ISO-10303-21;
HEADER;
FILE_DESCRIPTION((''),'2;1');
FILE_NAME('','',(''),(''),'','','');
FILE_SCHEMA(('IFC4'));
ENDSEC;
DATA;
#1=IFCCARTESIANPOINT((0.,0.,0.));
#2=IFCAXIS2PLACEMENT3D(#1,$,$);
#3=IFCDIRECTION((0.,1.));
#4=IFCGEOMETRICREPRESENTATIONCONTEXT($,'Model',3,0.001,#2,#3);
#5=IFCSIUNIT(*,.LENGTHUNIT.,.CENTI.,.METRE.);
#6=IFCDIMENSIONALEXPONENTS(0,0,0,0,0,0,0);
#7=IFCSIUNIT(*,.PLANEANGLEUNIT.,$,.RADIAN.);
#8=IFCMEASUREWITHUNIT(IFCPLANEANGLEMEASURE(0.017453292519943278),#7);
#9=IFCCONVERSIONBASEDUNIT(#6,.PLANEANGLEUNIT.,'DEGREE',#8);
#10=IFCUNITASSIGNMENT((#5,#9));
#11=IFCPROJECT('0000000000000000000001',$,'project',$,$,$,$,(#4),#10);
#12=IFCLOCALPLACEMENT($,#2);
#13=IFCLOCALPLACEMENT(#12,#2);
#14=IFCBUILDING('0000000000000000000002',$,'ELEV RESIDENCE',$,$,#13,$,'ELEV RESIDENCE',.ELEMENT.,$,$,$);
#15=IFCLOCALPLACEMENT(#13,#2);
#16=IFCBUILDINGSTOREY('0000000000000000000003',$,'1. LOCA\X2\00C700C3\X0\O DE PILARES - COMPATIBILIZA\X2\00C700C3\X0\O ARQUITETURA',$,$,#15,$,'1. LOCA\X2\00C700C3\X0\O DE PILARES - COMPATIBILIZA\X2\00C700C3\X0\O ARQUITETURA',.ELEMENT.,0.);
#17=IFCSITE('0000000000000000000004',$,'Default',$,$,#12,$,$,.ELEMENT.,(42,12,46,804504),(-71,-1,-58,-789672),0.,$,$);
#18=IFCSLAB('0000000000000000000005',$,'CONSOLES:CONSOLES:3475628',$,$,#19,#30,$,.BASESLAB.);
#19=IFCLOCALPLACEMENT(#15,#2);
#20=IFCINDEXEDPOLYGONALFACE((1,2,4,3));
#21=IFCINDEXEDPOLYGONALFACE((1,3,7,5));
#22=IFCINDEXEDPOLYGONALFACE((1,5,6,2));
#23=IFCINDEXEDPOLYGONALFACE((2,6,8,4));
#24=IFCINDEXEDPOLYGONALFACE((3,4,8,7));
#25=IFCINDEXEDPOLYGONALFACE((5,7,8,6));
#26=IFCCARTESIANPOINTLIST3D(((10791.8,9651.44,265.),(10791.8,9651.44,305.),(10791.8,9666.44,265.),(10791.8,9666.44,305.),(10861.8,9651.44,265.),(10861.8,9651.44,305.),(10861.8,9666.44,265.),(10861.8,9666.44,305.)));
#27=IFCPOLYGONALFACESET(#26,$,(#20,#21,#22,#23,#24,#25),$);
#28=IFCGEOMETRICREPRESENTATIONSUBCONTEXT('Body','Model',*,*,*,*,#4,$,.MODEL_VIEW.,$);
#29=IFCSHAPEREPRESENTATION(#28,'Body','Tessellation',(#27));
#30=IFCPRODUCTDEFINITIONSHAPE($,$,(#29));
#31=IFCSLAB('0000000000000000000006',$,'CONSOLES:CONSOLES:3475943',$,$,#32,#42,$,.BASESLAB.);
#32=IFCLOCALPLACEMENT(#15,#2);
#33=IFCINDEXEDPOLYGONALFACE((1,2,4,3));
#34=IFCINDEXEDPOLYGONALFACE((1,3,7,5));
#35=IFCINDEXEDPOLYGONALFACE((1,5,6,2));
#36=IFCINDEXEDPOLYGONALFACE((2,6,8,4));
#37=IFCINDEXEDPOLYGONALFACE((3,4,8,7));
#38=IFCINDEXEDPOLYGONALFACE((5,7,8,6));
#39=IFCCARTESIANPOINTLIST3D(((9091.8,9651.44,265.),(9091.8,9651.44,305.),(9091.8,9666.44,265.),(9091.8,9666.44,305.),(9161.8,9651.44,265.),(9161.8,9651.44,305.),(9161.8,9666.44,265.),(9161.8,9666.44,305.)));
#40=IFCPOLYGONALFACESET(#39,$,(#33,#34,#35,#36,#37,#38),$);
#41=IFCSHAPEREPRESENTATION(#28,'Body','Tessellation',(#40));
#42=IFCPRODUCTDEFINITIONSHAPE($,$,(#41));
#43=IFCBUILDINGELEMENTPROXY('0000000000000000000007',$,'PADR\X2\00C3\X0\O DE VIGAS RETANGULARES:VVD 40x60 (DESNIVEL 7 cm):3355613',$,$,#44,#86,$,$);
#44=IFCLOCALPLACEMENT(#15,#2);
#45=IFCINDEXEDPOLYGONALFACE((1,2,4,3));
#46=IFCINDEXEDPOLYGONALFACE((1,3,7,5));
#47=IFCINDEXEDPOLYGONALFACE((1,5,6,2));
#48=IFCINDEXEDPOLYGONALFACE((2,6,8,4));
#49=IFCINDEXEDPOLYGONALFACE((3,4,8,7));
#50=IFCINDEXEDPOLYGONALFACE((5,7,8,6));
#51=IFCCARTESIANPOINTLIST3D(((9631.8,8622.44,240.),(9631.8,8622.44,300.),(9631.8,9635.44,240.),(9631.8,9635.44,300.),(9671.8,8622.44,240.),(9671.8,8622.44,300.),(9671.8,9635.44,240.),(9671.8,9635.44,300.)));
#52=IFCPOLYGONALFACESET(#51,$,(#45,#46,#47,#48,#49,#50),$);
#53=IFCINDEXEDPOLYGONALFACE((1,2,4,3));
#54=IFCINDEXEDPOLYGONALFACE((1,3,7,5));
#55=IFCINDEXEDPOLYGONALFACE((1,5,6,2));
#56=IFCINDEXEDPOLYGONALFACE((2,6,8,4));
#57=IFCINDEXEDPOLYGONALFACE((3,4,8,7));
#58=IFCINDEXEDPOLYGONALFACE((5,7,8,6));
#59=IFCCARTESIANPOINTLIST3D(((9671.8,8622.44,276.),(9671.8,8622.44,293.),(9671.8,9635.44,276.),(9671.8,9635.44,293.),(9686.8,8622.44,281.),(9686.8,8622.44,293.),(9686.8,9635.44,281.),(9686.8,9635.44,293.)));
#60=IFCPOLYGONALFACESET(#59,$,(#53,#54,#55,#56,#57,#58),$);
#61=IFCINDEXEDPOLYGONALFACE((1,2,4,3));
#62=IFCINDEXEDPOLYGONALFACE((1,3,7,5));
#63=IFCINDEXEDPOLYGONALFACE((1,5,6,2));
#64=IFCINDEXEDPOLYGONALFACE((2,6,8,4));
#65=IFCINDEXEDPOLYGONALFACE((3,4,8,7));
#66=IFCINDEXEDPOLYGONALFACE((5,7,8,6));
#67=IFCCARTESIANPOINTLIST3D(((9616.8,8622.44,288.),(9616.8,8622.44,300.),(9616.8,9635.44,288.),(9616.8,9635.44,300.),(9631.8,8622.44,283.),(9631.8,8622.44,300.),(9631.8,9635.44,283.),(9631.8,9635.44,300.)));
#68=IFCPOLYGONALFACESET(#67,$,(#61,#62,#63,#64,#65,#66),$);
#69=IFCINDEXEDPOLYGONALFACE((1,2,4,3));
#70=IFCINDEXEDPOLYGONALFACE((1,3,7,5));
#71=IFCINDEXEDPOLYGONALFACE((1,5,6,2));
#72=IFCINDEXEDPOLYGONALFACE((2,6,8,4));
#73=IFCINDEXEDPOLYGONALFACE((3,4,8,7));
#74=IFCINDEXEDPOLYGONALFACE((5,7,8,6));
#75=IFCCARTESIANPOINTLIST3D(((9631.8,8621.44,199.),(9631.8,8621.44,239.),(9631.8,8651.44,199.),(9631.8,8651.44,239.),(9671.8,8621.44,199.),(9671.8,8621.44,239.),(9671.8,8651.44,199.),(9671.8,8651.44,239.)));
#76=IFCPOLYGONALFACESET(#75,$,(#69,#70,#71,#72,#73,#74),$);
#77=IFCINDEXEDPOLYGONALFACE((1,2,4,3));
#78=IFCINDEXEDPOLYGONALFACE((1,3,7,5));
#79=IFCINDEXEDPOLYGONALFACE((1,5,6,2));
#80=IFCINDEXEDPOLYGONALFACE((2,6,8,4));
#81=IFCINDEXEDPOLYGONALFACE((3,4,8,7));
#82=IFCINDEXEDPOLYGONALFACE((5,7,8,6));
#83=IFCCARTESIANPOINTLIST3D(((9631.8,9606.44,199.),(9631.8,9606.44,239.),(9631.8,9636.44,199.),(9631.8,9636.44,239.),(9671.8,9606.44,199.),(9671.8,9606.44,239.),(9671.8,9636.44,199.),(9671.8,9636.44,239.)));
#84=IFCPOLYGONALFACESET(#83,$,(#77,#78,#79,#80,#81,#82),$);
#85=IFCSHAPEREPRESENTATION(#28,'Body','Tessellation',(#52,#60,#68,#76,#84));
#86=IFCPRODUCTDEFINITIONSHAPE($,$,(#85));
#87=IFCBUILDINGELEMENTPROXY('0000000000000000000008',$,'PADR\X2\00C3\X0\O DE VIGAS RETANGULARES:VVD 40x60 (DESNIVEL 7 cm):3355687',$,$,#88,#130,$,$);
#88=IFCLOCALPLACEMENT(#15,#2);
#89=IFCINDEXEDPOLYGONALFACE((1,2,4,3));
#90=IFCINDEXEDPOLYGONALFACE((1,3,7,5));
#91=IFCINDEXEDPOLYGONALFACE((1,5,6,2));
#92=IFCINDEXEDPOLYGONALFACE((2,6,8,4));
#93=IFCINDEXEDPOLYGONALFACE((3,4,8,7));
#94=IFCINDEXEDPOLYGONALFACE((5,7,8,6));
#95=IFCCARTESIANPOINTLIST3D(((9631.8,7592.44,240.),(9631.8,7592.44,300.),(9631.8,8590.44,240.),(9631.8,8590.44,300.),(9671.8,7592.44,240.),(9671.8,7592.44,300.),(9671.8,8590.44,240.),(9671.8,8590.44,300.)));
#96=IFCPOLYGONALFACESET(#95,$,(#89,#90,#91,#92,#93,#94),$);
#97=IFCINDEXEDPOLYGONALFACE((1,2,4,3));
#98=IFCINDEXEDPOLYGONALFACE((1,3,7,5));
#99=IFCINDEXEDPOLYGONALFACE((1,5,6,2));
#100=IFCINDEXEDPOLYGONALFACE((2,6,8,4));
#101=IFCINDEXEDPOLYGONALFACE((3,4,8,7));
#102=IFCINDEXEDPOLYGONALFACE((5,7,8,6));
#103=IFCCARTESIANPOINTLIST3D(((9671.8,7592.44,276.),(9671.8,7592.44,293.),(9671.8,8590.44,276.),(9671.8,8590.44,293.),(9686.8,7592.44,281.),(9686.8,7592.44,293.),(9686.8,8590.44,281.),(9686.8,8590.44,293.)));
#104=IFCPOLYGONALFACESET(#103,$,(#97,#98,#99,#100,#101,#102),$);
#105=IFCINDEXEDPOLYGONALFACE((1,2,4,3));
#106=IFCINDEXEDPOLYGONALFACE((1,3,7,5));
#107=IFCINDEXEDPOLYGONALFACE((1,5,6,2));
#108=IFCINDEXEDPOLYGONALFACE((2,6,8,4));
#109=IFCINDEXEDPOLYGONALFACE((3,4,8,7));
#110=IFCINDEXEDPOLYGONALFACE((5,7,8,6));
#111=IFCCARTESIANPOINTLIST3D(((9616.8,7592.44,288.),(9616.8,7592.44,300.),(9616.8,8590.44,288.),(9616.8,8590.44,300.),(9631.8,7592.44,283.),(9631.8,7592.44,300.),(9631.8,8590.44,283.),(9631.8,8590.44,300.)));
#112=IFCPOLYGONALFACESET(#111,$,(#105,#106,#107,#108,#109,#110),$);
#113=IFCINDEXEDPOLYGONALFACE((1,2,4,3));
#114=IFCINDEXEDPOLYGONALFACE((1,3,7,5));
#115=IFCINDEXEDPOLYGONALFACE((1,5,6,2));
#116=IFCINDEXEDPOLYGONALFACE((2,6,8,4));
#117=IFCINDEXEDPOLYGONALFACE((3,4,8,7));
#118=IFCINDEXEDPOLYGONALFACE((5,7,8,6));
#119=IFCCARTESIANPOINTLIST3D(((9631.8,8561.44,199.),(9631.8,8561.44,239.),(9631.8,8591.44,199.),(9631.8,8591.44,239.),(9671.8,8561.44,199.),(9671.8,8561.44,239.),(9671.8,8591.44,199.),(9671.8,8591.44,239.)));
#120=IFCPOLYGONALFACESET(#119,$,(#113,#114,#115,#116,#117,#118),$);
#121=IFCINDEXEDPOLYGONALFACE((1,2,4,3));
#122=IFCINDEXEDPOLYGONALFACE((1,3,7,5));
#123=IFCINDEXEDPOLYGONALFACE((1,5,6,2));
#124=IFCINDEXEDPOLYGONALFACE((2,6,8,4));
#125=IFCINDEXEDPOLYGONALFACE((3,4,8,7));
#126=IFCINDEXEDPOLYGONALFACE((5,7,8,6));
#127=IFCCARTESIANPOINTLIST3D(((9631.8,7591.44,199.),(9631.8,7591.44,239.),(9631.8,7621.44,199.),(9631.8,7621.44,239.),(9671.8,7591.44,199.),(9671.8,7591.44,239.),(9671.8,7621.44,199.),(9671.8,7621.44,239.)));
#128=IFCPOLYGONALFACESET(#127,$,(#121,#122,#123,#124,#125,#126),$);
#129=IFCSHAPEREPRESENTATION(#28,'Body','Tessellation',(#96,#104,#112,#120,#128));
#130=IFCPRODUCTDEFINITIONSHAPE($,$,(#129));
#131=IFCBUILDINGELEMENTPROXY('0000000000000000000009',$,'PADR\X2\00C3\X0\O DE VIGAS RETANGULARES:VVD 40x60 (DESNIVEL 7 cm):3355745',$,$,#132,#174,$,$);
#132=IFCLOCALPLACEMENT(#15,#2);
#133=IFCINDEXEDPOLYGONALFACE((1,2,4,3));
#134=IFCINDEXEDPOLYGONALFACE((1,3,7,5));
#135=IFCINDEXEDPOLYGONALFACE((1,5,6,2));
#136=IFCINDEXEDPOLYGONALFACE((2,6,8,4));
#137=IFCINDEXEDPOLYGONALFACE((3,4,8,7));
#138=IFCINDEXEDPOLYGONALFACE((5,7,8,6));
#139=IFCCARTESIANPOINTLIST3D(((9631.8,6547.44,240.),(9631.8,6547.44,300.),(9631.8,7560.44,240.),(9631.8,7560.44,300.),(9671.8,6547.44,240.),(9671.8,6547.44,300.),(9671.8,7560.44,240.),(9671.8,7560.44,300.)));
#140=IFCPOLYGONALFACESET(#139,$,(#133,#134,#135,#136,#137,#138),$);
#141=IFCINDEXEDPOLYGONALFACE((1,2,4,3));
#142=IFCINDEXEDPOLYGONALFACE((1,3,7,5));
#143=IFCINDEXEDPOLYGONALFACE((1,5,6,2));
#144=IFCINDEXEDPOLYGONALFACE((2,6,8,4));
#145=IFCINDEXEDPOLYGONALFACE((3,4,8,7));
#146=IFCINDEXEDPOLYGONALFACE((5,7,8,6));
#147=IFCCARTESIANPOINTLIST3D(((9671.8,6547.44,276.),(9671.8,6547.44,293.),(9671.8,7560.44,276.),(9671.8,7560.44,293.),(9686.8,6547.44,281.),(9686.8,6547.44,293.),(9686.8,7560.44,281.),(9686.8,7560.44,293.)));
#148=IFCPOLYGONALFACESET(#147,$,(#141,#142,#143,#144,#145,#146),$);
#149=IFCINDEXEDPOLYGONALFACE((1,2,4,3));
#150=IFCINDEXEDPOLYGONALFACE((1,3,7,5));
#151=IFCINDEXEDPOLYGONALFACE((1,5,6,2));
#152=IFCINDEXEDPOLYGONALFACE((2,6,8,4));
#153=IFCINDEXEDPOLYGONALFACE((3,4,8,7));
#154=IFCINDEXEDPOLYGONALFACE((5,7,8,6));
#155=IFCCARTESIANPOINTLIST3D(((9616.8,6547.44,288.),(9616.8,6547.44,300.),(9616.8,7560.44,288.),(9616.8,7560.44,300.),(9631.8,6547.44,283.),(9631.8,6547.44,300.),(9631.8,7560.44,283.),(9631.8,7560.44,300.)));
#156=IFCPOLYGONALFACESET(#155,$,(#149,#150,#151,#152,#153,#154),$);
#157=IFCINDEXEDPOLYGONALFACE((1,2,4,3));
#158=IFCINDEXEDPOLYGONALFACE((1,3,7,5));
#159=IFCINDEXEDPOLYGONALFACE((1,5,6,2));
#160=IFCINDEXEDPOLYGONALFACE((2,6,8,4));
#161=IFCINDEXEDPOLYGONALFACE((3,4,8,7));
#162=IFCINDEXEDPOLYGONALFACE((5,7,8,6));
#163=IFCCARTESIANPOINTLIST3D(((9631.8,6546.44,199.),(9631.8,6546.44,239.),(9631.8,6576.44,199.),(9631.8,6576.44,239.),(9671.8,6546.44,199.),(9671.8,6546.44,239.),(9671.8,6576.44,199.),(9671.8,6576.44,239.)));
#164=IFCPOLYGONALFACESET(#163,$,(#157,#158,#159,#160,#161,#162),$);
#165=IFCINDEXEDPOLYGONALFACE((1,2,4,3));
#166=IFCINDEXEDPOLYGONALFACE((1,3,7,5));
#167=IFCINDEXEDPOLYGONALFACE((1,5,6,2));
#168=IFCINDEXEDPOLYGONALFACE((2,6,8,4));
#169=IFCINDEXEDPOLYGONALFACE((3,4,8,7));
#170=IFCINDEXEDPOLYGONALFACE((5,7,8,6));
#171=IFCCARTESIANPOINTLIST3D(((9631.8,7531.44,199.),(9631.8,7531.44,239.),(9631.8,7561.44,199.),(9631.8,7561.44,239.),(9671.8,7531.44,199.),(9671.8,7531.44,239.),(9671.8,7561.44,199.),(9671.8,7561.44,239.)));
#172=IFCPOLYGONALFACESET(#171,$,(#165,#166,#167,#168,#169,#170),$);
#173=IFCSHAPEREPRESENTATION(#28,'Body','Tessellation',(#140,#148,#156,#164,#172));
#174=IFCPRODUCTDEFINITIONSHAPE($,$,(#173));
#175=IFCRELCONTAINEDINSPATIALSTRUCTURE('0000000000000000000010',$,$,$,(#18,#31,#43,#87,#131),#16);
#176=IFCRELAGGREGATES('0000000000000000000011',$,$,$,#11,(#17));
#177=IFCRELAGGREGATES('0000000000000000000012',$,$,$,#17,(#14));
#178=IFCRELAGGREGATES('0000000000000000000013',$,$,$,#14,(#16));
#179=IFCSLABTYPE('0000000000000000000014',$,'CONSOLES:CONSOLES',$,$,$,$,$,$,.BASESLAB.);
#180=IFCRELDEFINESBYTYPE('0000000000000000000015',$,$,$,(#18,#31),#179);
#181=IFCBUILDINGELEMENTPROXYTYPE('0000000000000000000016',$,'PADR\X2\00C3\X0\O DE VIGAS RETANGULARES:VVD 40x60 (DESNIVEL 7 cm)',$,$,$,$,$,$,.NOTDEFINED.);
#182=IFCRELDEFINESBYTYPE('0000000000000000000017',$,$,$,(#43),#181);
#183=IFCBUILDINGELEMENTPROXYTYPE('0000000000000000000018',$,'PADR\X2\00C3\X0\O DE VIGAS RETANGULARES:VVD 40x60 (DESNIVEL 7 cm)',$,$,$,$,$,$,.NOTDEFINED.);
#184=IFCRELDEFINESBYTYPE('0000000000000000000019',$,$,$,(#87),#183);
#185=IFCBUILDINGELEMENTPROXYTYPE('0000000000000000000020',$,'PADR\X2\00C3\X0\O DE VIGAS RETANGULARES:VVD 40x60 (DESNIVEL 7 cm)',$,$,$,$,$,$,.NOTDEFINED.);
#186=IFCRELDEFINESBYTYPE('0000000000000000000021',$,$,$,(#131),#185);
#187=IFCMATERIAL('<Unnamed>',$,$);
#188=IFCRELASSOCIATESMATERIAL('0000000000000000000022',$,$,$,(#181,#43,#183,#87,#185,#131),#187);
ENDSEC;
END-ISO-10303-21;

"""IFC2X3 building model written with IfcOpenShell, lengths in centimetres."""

from ifc_helpers import new_model, entity, si_unit, converted_unit, direction, frame, frame_2d, origin, place, context, subcontext, project, spatial, polyline, rectangle, outline, extrude, source, transform, mapped, material, type_object, type_shapes, element, save


model = new_model("IFC2X3")

# Units and contexts
model_context = context("Model", 3, precision=0.001, world=origin(), true_north=direction((0.0, 1.0)))
body_context = subcontext(model_context, "Body", "Model", "MODEL_VIEW")
ifc_project = project(units=[si_unit("LENGTHUNIT", "METRE", prefix="CENTI"), converted_unit("PLANEANGLEUNIT", "DEGREE", entity("IfcPlaneAngleMeasure", 0.017453292519943278), si_unit("PLANEANGLEUNIT", "RADIAN"), dimensions=[0, 0, 0, 0, 0, 0, 0])], contexts=[model_context])

# Site, building, storey
site_placement = place(None, origin())
site = spatial("IfcSite", under=ifc_project, at=site_placement, Name="Default", CompositionType="ELEMENT", RefLatitude=(42, 12, 46, 804504), RefLongitude=(-71, -1, -58, -789672), RefElevation=0.0)
building_placement = place(site_placement, origin())
building = spatial("IfcBuilding", under=site, at=building_placement, Name="ELEV RESIDENCE", LongName="ELEV RESIDENCE", CompositionType="ELEMENT")
storey_placement = place(building_placement, origin())
storey = spatial("IfcBuildingStorey", under=building, at=storey_placement, Name="1. LOCAÇÃO DE PILARES - COMPATIBILIZAÇÃO ARQUITETURA", LongName="1. LOCAÇÃO DE PILARES - COMPATIBILIZAÇÃO ARQUITETURA", CompositionType="ELEMENT", Elevation=0.0)

# Slabs
slab_type = type_object("IfcSlabType", Name="CONSOLES:CONSOLES", PredefinedType="BASESLAB")
slab_1_placement = place(storey_placement, origin())
element("IfcSlab", 1, at=slab_1_placement, inside=storey, type_object=slab_type, Name="CONSOLES:CONSOLES:3475628", PredefinedType="BASESLAB", context=body_context, shape_type="SweptSolid", body=[
    extrude(rectangle(XDim=15.0, YDim=70.0, at=frame_2d((0.0, 0.0), x_axis=(1.0, 0.0))), frame((10826.8, 9658.94, 265.0), z_axis=(0.0, 0.0, 1.0), x_axis=(0.0, 1.0, 0.0)), (0.0, 0.0, 1.0), 40.0),
])
slab_2_placement = place(storey_placement, origin())
element("IfcSlab", 2, at=slab_2_placement, inside=storey, type_object=slab_type, Name="CONSOLES:CONSOLES:3475943", PredefinedType="BASESLAB", context=body_context, shape_type="SweptSolid", body=[
    extrude(rectangle(XDim=70.0, YDim=15.0, at=frame_2d((0.0, 0.0), x_axis=(1.0, 0.0))), frame((9126.8, 9658.94, 265.0)), (0.0, 0.0, 1.0), 40.0),
])

# Building element proxies
ifc_material_1 = material(Name="<Unnamed>")
building_element_proxy_type_1 = type_object("IfcBuildingElementProxyType", Name="PADRÃO DE VIGAS RETANGULARES:VVD 40x60 (DESNIVEL 7 cm)", PredefinedType="NOTDEFINED", material=ifc_material_1)
shared_shape_1 = source(origin(), body_context, "Body", "SweptSolid", [
    extrude(rectangle(XDim=1013.0, YDim=40.0, at=frame_2d((0.0, 0.0), x_axis=(1.0, 0.0))), frame((9651.8, 9128.94, 240.0), z_axis=(0.0, 0.0, 1.0), x_axis=(0.0, -1.0, 0.0)), (0.0, 0.0, 1.0), 60.0),
    extrude(outline(polyline([(-7.25, -7.5), (4.75, -7.5), (9.75, 7.5), (-7.25, 7.5), (-7.25, -7.5)])), frame((9679.3, 8622.44, 285.75), z_axis=(0.0, 1.0, 0.0), x_axis=(0.0, 0.0, -1.0)), (0.0, 0.0, 1.0), 1013.0),
    extrude(outline(polyline([(-7.5, -7.25), (7.5, -7.25), (7.5, 9.75), (-7.5, 4.75), (-7.5, -7.25)])), frame((9624.3, 8622.44, 292.75), z_axis=(0.0, 1.0, 0.0), x_axis=(1.0, 0.0, 0.0)), (0.0, 0.0, 1.0), 1013.0),
    extrude(rectangle(XDim=40.0, YDim=30.0, at=frame_2d((0.0, 0.0), x_axis=(1.0, 0.0))), frame((9651.8, 8636.44, 199.0), z_axis=(0.0, 0.0, 1.0), x_axis=(-1.0, 0.0, 0.0)), (0.0, 0.0, 1.0), 40.0),
    extrude(rectangle(XDim=40.0, YDim=30.0, at=frame_2d((0.0, 0.0), x_axis=(1.0, 0.0))), frame((9651.8, 9621.44, 199.0), z_axis=(0.0, 0.0, 1.0), x_axis=(-1.0, 0.0, 0.0)), (0.0, 0.0, 1.0), 40.0),
])
type_shapes(building_element_proxy_type_1, [shared_shape_1])
proxy_1_placement = place(storey_placement, origin())
element("IfcBuildingElementProxy", 3, at=proxy_1_placement, inside=storey, type_object=building_element_proxy_type_1, material=ifc_material_1, Name="PADRÃO DE VIGAS RETANGULARES:VVD 40x60 (DESNIVEL 7 cm):3355613", context=body_context, shape_type="MappedRepresentation", body=[
    mapped(shared_shape_1, transform((0.0, 0.0, 0.0), scale=1.0)),
])
building_element_proxy_type_2 = type_object("IfcBuildingElementProxyType", Name="PADRÃO DE VIGAS RETANGULARES:VVD 40x60 (DESNIVEL 7 cm)", PredefinedType="NOTDEFINED", material=ifc_material_1)
shared_shape_2 = source(origin(), body_context, "Body", "SweptSolid", [
    extrude(rectangle(XDim=40.0, YDim=998.0, at=frame_2d((0.0, 0.0), x_axis=(1.0, 0.0))), frame((9651.8, 8091.44, 240.0)), (0.0, 0.0, 1.0), 60.0),
    extrude(outline(polyline([(-7.25, -7.5), (4.75, -7.5), (9.75, 7.5), (-7.25, 7.5), (-7.25, -7.5)])), frame((9679.3, 7592.44, 285.75), z_axis=(0.0, 1.0, 0.0), x_axis=(0.0, 0.0, -1.0)), (0.0, 0.0, 1.0), 998.0),
    extrude(outline(polyline([(-7.5, -7.25), (7.5, -7.25), (7.5, 9.75), (-7.5, 4.75), (-7.5, -7.25)])), frame((9624.3, 7592.44, 292.75), z_axis=(0.0, 1.0, 0.0), x_axis=(1.0, 0.0, 0.0)), (0.0, 0.0, 1.0), 998.0),
    extrude(rectangle(XDim=30.0, YDim=40.0, at=frame_2d((0.0, 0.0), x_axis=(1.0, 0.0))), frame((9651.8, 8576.44, 199.0), z_axis=(0.0, 0.0, 1.0), x_axis=(0.0, 1.0, 0.0)), (0.0, 0.0, 1.0), 40.0),
    extrude(rectangle(XDim=30.0, YDim=40.0, at=frame_2d((0.0, 0.0), x_axis=(1.0, 0.0))), frame((9651.8, 7606.44, 199.0), z_axis=(0.0, 0.0, 1.0), x_axis=(0.0, 1.0, 0.0)), (0.0, 0.0, 1.0), 40.0),
])
type_shapes(building_element_proxy_type_2, [shared_shape_2])
proxy_2_placement = place(storey_placement, origin())
element("IfcBuildingElementProxy", 4, at=proxy_2_placement, inside=storey, type_object=building_element_proxy_type_2, material=ifc_material_1, Name="PADRÃO DE VIGAS RETANGULARES:VVD 40x60 (DESNIVEL 7 cm):3355687", context=body_context, shape_type="MappedRepresentation", body=[
    mapped(shared_shape_2, transform((0.0, 0.0, 0.0), scale=1.0)),
])
building_element_proxy_type_3 = type_object("IfcBuildingElementProxyType", Name="PADRÃO DE VIGAS RETANGULARES:VVD 40x60 (DESNIVEL 7 cm)", PredefinedType="NOTDEFINED", material=ifc_material_1)
shared_shape_3 = source(origin(), body_context, "Body", "SweptSolid", [
    extrude(rectangle(XDim=1013.0, YDim=40.0, at=frame_2d((0.0, 0.0), x_axis=(1.0, 0.0))), frame((9651.8, 7053.94, 240.0), z_axis=(0.0, 0.0, 1.0), x_axis=(0.0, -1.0, 0.0)), (0.0, 0.0, 1.0), 60.0),
    extrude(outline(polyline([(-7.25, -7.5), (4.75, -7.5), (9.75, 7.5), (-7.25, 7.5), (-7.25, -7.5)])), frame((9679.3, 6547.44, 285.75), z_axis=(0.0, 1.0, 0.0), x_axis=(0.0, 0.0, -1.0)), (0.0, 0.0, 1.0), 1013.0),
    extrude(outline(polyline([(-7.5, -7.25), (7.5, -7.25), (7.5, 9.75), (-7.5, 4.75), (-7.5, -7.25)])), frame((9624.3, 6547.44, 292.75), z_axis=(0.0, 1.0, 0.0), x_axis=(1.0, 0.0, 0.0)), (0.0, 0.0, 1.0), 1013.0),
    extrude(rectangle(XDim=40.0, YDim=30.0, at=frame_2d((0.0, 0.0), x_axis=(1.0, 0.0))), frame((9651.8, 6561.44, 199.0), z_axis=(0.0, 0.0, 1.0), x_axis=(-1.0, 0.0, 0.0)), (0.0, 0.0, 1.0), 40.0),
    extrude(rectangle(XDim=40.0, YDim=30.0, at=frame_2d((0.0, 0.0), x_axis=(1.0, 0.0))), frame((9651.8, 7546.44, 199.0), z_axis=(0.0, 0.0, 1.0), x_axis=(-1.0, 0.0, 0.0)), (0.0, 0.0, 1.0), 40.0),
])
type_shapes(building_element_proxy_type_3, [shared_shape_3])
proxy_3_placement = place(storey_placement, origin())
element("IfcBuildingElementProxy", 5, at=proxy_3_placement, inside=storey, type_object=building_element_proxy_type_3, material=ifc_material_1, Name="PADRÃO DE VIGAS RETANGULARES:VVD 40x60 (DESNIVEL 7 cm):3355745", context=body_context, shape_type="MappedRepresentation", body=[
    mapped(shared_shape_3, transform((0.0, 0.0, 0.0), scale=1.0)),
])

save(model, "model.ifc")
